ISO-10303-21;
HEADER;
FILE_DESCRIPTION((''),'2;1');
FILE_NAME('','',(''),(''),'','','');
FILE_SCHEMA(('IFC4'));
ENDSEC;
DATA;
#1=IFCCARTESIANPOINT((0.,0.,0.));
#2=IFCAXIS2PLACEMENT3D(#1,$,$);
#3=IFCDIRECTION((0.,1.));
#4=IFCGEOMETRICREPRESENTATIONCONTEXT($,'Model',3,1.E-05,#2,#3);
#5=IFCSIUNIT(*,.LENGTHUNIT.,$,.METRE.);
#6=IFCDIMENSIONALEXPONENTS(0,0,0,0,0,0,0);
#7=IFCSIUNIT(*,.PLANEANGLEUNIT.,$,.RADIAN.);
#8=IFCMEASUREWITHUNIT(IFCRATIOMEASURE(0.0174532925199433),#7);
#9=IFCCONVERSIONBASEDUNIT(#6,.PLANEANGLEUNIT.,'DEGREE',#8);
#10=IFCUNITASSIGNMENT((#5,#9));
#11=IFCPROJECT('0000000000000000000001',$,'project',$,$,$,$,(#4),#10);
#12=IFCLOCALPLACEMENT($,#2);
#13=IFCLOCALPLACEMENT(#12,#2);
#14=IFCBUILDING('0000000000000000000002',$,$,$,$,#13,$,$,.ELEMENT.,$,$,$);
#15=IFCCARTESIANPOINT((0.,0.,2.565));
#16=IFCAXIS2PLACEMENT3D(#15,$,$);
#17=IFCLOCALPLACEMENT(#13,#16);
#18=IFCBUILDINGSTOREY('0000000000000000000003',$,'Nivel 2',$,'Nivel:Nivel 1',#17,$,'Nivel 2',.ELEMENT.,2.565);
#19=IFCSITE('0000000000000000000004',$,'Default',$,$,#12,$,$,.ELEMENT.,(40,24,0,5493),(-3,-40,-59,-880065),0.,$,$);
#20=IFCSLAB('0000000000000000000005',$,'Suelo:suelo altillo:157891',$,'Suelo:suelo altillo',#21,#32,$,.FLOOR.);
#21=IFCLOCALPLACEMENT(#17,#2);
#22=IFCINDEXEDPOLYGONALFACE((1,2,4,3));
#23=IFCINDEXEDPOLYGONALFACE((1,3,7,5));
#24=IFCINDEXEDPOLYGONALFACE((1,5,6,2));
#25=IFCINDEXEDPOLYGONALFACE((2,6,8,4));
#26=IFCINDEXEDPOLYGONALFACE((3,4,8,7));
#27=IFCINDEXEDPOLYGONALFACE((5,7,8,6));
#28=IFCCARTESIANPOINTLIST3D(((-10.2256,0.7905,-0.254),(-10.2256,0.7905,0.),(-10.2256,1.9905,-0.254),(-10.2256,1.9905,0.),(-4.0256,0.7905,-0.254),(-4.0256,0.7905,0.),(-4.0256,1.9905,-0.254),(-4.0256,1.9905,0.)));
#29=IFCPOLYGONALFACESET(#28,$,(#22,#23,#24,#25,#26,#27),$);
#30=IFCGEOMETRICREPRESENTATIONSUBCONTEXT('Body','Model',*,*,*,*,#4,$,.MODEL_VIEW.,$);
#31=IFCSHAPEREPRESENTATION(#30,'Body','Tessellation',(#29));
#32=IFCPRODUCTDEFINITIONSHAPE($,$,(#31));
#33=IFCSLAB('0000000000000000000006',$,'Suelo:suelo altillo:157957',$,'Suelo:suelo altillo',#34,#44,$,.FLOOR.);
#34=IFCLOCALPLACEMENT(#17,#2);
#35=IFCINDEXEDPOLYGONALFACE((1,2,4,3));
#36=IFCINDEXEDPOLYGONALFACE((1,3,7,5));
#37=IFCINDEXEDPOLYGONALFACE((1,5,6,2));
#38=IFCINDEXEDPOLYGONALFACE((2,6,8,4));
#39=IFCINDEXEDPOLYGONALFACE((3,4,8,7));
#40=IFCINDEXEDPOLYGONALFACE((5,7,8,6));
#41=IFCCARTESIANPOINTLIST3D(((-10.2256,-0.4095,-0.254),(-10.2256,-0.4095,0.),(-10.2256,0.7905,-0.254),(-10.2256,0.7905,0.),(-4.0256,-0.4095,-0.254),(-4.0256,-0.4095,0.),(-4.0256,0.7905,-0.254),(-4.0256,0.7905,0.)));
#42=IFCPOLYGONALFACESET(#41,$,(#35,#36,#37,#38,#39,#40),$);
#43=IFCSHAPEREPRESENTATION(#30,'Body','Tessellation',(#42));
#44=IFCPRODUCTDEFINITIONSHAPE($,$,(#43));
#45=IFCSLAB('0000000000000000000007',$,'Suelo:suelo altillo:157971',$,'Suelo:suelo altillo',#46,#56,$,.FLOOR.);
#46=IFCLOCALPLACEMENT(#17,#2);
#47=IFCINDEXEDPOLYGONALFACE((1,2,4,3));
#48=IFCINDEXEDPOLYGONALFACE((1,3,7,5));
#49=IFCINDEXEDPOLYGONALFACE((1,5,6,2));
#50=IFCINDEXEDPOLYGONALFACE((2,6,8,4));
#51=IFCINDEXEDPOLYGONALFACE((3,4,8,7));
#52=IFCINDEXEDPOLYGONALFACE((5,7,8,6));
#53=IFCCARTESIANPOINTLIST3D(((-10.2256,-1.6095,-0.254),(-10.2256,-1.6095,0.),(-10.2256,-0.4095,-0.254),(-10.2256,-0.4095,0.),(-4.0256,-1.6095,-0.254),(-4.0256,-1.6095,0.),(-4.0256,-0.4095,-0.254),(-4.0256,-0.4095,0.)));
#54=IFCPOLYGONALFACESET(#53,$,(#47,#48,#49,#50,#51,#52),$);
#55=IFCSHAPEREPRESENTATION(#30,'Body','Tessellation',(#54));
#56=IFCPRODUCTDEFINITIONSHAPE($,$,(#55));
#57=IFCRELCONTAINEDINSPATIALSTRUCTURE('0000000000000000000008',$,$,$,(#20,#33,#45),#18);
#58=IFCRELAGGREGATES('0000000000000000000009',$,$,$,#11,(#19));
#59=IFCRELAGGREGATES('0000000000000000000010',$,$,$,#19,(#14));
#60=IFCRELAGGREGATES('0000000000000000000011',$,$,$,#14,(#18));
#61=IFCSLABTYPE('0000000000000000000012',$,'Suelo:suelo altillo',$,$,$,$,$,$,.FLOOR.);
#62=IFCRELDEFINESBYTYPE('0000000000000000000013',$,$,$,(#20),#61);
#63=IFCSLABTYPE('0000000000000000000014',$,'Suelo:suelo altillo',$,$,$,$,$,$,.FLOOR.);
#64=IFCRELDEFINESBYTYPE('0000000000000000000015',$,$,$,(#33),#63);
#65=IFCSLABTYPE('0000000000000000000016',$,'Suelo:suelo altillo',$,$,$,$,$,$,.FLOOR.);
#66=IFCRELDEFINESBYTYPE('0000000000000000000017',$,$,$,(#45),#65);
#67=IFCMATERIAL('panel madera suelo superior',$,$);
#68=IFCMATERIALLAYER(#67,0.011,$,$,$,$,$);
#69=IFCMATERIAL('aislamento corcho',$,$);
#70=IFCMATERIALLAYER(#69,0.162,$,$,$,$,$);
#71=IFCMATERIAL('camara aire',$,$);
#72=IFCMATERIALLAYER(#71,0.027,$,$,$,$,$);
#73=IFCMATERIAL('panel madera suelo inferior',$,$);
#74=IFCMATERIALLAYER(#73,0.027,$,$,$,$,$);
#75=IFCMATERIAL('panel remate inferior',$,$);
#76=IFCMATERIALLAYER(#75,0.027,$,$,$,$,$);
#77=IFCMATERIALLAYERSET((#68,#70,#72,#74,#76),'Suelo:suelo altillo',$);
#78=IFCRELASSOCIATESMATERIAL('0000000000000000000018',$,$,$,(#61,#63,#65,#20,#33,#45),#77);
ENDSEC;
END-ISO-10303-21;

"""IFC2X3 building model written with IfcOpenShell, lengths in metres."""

from ifc_helpers import new_model, entity, si_unit, converted_unit, direction, frame, frame_2d, origin, place, context, subcontext, project, spatial, rectangle, extrude, material, layer, layer_set, layer_usage, type_object, element, save


model = new_model("IFC2X3")

# Units and contexts
model_context = context("Model", 3, precision=1e-05, world=origin(), true_north=direction((0.0, 1.0)))
body_context = subcontext(model_context, "Body", "Model", "MODEL_VIEW")
ifc_project = project(units=[si_unit("LENGTHUNIT", "METRE"), converted_unit("PLANEANGLEUNIT", "DEGREE", entity("IfcRatioMeasure", 0.0174532925199433), si_unit("PLANEANGLEUNIT", "RADIAN"), dimensions=[0, 0, 0, 0, 0, 0, 0])], contexts=[model_context])

# Site, building, storey
site_placement = place(None, origin())
site = spatial("IfcSite", under=ifc_project, at=site_placement, Name="Default", CompositionType="ELEMENT", RefLatitude=(40, 24, 0, 5493), RefLongitude=(-3, -40, -59, -880065), RefElevation=0.0)
building_placement = place(site_placement, origin())
building = spatial("IfcBuilding", under=site, at=building_placement, CompositionType="ELEMENT")
storey_placement = place(building_placement, frame((0.0, 0.0, 2.565)))
storey = spatial("IfcBuildingStorey", under=building, at=storey_placement, Name="Nivel 2", ObjectType="Nivel:Nivel 1", LongName="Nivel 2", CompositionType="ELEMENT", Elevation=2.565)

# Slabs
ifc_material_1 = material(Name="panel madera suelo superior")
ifc_layer_1 = layer(ifc_material_1, 0.011)
ifc_material_2 = material(Name="aislamento corcho")
ifc_layer_2 = layer(ifc_material_2, 0.162)
ifc_material_3 = material(Name="camara aire")
ifc_layer_3 = layer(ifc_material_3, 0.027)
ifc_material_4 = material(Name="panel madera suelo inferior")
ifc_layer_4 = layer(ifc_material_4, 0.027)
ifc_material_5 = material(Name="panel remate inferior")
ifc_layer_5 = layer(ifc_material_5, 0.027)
ifc_layer_set = layer_set([ifc_layer_1, ifc_layer_2, ifc_layer_3, ifc_layer_4, ifc_layer_5], Name="Suelo:suelo altillo")
ifc_layer_usage_1 = layer_usage(ifc_layer_set, "AXIS3", "POSITIVE", 0.0)
slab_type_1 = type_object("IfcSlabType", Name="Suelo:suelo altillo", PredefinedType="FLOOR", material=ifc_layer_set)
slab_1_placement = place(storey_placement, origin())
element("IfcSlab", 1, at=slab_1_placement, inside=storey, type_object=slab_type_1, material=ifc_layer_usage_1, Name="Suelo:suelo altillo:157891", ObjectType="Suelo:suelo altillo", PredefinedType="FLOOR", context=body_context, shape_type="SweptSolid", body=[
    extrude(rectangle(XDim=1.2, YDim=6.2, at=frame_2d((0.0, 0.0), x_axis=(1.0, 0.0))), frame((-7.1256, 1.3905, 0.0), z_axis=(0.0, 0.0, -1.0), x_axis=(0.0, 1.0, 0.0)), (0.0, 0.0, 1.0), 0.254),
])
ifc_layer_usage_2 = layer_usage(ifc_layer_set, "AXIS3", "POSITIVE", 0.0)
slab_type_2 = type_object("IfcSlabType", Name="Suelo:suelo altillo", PredefinedType="FLOOR", material=ifc_layer_set)
slab_2_placement = place(storey_placement, origin())
element("IfcSlab", 2, at=slab_2_placement, inside=storey, type_object=slab_type_2, material=ifc_layer_usage_2, Name="Suelo:suelo altillo:157957", ObjectType="Suelo:suelo altillo", PredefinedType="FLOOR", context=body_context, shape_type="SweptSolid", body=[
    extrude(rectangle(XDim=1.2, YDim=6.2, at=frame_2d((0.0, 0.0), x_axis=(1.0, 0.0))), frame((-7.1256, 0.1905, 0.0), z_axis=(0.0, 0.0, -1.0), x_axis=(0.0, 1.0, 0.0)), (0.0, 0.0, 1.0), 0.254),
])
ifc_layer_usage_3 = layer_usage(ifc_layer_set, "AXIS3", "POSITIVE", 0.0)
slab_type_3 = type_object("IfcSlabType", Name="Suelo:suelo altillo", PredefinedType="FLOOR", material=ifc_layer_set)
slab_3_placement = place(storey_placement, origin())
element("IfcSlab", 3, at=slab_3_placement, inside=storey, type_object=slab_type_3, material=ifc_layer_usage_3, Name="Suelo:suelo altillo:157971", ObjectType="Suelo:suelo altillo", PredefinedType="FLOOR", context=body_context, shape_type="SweptSolid", body=[
    extrude(rectangle(XDim=1.2, YDim=6.2, at=frame_2d((0.0, 0.0), x_axis=(1.0, 0.0))), frame((-7.1256, -1.0095, 0.0), z_axis=(0.0, 0.0, -1.0), x_axis=(0.0, 1.0, 0.0)), (0.0, 0.0, 1.0), 0.254),
])

save(model, "model.ifc")
